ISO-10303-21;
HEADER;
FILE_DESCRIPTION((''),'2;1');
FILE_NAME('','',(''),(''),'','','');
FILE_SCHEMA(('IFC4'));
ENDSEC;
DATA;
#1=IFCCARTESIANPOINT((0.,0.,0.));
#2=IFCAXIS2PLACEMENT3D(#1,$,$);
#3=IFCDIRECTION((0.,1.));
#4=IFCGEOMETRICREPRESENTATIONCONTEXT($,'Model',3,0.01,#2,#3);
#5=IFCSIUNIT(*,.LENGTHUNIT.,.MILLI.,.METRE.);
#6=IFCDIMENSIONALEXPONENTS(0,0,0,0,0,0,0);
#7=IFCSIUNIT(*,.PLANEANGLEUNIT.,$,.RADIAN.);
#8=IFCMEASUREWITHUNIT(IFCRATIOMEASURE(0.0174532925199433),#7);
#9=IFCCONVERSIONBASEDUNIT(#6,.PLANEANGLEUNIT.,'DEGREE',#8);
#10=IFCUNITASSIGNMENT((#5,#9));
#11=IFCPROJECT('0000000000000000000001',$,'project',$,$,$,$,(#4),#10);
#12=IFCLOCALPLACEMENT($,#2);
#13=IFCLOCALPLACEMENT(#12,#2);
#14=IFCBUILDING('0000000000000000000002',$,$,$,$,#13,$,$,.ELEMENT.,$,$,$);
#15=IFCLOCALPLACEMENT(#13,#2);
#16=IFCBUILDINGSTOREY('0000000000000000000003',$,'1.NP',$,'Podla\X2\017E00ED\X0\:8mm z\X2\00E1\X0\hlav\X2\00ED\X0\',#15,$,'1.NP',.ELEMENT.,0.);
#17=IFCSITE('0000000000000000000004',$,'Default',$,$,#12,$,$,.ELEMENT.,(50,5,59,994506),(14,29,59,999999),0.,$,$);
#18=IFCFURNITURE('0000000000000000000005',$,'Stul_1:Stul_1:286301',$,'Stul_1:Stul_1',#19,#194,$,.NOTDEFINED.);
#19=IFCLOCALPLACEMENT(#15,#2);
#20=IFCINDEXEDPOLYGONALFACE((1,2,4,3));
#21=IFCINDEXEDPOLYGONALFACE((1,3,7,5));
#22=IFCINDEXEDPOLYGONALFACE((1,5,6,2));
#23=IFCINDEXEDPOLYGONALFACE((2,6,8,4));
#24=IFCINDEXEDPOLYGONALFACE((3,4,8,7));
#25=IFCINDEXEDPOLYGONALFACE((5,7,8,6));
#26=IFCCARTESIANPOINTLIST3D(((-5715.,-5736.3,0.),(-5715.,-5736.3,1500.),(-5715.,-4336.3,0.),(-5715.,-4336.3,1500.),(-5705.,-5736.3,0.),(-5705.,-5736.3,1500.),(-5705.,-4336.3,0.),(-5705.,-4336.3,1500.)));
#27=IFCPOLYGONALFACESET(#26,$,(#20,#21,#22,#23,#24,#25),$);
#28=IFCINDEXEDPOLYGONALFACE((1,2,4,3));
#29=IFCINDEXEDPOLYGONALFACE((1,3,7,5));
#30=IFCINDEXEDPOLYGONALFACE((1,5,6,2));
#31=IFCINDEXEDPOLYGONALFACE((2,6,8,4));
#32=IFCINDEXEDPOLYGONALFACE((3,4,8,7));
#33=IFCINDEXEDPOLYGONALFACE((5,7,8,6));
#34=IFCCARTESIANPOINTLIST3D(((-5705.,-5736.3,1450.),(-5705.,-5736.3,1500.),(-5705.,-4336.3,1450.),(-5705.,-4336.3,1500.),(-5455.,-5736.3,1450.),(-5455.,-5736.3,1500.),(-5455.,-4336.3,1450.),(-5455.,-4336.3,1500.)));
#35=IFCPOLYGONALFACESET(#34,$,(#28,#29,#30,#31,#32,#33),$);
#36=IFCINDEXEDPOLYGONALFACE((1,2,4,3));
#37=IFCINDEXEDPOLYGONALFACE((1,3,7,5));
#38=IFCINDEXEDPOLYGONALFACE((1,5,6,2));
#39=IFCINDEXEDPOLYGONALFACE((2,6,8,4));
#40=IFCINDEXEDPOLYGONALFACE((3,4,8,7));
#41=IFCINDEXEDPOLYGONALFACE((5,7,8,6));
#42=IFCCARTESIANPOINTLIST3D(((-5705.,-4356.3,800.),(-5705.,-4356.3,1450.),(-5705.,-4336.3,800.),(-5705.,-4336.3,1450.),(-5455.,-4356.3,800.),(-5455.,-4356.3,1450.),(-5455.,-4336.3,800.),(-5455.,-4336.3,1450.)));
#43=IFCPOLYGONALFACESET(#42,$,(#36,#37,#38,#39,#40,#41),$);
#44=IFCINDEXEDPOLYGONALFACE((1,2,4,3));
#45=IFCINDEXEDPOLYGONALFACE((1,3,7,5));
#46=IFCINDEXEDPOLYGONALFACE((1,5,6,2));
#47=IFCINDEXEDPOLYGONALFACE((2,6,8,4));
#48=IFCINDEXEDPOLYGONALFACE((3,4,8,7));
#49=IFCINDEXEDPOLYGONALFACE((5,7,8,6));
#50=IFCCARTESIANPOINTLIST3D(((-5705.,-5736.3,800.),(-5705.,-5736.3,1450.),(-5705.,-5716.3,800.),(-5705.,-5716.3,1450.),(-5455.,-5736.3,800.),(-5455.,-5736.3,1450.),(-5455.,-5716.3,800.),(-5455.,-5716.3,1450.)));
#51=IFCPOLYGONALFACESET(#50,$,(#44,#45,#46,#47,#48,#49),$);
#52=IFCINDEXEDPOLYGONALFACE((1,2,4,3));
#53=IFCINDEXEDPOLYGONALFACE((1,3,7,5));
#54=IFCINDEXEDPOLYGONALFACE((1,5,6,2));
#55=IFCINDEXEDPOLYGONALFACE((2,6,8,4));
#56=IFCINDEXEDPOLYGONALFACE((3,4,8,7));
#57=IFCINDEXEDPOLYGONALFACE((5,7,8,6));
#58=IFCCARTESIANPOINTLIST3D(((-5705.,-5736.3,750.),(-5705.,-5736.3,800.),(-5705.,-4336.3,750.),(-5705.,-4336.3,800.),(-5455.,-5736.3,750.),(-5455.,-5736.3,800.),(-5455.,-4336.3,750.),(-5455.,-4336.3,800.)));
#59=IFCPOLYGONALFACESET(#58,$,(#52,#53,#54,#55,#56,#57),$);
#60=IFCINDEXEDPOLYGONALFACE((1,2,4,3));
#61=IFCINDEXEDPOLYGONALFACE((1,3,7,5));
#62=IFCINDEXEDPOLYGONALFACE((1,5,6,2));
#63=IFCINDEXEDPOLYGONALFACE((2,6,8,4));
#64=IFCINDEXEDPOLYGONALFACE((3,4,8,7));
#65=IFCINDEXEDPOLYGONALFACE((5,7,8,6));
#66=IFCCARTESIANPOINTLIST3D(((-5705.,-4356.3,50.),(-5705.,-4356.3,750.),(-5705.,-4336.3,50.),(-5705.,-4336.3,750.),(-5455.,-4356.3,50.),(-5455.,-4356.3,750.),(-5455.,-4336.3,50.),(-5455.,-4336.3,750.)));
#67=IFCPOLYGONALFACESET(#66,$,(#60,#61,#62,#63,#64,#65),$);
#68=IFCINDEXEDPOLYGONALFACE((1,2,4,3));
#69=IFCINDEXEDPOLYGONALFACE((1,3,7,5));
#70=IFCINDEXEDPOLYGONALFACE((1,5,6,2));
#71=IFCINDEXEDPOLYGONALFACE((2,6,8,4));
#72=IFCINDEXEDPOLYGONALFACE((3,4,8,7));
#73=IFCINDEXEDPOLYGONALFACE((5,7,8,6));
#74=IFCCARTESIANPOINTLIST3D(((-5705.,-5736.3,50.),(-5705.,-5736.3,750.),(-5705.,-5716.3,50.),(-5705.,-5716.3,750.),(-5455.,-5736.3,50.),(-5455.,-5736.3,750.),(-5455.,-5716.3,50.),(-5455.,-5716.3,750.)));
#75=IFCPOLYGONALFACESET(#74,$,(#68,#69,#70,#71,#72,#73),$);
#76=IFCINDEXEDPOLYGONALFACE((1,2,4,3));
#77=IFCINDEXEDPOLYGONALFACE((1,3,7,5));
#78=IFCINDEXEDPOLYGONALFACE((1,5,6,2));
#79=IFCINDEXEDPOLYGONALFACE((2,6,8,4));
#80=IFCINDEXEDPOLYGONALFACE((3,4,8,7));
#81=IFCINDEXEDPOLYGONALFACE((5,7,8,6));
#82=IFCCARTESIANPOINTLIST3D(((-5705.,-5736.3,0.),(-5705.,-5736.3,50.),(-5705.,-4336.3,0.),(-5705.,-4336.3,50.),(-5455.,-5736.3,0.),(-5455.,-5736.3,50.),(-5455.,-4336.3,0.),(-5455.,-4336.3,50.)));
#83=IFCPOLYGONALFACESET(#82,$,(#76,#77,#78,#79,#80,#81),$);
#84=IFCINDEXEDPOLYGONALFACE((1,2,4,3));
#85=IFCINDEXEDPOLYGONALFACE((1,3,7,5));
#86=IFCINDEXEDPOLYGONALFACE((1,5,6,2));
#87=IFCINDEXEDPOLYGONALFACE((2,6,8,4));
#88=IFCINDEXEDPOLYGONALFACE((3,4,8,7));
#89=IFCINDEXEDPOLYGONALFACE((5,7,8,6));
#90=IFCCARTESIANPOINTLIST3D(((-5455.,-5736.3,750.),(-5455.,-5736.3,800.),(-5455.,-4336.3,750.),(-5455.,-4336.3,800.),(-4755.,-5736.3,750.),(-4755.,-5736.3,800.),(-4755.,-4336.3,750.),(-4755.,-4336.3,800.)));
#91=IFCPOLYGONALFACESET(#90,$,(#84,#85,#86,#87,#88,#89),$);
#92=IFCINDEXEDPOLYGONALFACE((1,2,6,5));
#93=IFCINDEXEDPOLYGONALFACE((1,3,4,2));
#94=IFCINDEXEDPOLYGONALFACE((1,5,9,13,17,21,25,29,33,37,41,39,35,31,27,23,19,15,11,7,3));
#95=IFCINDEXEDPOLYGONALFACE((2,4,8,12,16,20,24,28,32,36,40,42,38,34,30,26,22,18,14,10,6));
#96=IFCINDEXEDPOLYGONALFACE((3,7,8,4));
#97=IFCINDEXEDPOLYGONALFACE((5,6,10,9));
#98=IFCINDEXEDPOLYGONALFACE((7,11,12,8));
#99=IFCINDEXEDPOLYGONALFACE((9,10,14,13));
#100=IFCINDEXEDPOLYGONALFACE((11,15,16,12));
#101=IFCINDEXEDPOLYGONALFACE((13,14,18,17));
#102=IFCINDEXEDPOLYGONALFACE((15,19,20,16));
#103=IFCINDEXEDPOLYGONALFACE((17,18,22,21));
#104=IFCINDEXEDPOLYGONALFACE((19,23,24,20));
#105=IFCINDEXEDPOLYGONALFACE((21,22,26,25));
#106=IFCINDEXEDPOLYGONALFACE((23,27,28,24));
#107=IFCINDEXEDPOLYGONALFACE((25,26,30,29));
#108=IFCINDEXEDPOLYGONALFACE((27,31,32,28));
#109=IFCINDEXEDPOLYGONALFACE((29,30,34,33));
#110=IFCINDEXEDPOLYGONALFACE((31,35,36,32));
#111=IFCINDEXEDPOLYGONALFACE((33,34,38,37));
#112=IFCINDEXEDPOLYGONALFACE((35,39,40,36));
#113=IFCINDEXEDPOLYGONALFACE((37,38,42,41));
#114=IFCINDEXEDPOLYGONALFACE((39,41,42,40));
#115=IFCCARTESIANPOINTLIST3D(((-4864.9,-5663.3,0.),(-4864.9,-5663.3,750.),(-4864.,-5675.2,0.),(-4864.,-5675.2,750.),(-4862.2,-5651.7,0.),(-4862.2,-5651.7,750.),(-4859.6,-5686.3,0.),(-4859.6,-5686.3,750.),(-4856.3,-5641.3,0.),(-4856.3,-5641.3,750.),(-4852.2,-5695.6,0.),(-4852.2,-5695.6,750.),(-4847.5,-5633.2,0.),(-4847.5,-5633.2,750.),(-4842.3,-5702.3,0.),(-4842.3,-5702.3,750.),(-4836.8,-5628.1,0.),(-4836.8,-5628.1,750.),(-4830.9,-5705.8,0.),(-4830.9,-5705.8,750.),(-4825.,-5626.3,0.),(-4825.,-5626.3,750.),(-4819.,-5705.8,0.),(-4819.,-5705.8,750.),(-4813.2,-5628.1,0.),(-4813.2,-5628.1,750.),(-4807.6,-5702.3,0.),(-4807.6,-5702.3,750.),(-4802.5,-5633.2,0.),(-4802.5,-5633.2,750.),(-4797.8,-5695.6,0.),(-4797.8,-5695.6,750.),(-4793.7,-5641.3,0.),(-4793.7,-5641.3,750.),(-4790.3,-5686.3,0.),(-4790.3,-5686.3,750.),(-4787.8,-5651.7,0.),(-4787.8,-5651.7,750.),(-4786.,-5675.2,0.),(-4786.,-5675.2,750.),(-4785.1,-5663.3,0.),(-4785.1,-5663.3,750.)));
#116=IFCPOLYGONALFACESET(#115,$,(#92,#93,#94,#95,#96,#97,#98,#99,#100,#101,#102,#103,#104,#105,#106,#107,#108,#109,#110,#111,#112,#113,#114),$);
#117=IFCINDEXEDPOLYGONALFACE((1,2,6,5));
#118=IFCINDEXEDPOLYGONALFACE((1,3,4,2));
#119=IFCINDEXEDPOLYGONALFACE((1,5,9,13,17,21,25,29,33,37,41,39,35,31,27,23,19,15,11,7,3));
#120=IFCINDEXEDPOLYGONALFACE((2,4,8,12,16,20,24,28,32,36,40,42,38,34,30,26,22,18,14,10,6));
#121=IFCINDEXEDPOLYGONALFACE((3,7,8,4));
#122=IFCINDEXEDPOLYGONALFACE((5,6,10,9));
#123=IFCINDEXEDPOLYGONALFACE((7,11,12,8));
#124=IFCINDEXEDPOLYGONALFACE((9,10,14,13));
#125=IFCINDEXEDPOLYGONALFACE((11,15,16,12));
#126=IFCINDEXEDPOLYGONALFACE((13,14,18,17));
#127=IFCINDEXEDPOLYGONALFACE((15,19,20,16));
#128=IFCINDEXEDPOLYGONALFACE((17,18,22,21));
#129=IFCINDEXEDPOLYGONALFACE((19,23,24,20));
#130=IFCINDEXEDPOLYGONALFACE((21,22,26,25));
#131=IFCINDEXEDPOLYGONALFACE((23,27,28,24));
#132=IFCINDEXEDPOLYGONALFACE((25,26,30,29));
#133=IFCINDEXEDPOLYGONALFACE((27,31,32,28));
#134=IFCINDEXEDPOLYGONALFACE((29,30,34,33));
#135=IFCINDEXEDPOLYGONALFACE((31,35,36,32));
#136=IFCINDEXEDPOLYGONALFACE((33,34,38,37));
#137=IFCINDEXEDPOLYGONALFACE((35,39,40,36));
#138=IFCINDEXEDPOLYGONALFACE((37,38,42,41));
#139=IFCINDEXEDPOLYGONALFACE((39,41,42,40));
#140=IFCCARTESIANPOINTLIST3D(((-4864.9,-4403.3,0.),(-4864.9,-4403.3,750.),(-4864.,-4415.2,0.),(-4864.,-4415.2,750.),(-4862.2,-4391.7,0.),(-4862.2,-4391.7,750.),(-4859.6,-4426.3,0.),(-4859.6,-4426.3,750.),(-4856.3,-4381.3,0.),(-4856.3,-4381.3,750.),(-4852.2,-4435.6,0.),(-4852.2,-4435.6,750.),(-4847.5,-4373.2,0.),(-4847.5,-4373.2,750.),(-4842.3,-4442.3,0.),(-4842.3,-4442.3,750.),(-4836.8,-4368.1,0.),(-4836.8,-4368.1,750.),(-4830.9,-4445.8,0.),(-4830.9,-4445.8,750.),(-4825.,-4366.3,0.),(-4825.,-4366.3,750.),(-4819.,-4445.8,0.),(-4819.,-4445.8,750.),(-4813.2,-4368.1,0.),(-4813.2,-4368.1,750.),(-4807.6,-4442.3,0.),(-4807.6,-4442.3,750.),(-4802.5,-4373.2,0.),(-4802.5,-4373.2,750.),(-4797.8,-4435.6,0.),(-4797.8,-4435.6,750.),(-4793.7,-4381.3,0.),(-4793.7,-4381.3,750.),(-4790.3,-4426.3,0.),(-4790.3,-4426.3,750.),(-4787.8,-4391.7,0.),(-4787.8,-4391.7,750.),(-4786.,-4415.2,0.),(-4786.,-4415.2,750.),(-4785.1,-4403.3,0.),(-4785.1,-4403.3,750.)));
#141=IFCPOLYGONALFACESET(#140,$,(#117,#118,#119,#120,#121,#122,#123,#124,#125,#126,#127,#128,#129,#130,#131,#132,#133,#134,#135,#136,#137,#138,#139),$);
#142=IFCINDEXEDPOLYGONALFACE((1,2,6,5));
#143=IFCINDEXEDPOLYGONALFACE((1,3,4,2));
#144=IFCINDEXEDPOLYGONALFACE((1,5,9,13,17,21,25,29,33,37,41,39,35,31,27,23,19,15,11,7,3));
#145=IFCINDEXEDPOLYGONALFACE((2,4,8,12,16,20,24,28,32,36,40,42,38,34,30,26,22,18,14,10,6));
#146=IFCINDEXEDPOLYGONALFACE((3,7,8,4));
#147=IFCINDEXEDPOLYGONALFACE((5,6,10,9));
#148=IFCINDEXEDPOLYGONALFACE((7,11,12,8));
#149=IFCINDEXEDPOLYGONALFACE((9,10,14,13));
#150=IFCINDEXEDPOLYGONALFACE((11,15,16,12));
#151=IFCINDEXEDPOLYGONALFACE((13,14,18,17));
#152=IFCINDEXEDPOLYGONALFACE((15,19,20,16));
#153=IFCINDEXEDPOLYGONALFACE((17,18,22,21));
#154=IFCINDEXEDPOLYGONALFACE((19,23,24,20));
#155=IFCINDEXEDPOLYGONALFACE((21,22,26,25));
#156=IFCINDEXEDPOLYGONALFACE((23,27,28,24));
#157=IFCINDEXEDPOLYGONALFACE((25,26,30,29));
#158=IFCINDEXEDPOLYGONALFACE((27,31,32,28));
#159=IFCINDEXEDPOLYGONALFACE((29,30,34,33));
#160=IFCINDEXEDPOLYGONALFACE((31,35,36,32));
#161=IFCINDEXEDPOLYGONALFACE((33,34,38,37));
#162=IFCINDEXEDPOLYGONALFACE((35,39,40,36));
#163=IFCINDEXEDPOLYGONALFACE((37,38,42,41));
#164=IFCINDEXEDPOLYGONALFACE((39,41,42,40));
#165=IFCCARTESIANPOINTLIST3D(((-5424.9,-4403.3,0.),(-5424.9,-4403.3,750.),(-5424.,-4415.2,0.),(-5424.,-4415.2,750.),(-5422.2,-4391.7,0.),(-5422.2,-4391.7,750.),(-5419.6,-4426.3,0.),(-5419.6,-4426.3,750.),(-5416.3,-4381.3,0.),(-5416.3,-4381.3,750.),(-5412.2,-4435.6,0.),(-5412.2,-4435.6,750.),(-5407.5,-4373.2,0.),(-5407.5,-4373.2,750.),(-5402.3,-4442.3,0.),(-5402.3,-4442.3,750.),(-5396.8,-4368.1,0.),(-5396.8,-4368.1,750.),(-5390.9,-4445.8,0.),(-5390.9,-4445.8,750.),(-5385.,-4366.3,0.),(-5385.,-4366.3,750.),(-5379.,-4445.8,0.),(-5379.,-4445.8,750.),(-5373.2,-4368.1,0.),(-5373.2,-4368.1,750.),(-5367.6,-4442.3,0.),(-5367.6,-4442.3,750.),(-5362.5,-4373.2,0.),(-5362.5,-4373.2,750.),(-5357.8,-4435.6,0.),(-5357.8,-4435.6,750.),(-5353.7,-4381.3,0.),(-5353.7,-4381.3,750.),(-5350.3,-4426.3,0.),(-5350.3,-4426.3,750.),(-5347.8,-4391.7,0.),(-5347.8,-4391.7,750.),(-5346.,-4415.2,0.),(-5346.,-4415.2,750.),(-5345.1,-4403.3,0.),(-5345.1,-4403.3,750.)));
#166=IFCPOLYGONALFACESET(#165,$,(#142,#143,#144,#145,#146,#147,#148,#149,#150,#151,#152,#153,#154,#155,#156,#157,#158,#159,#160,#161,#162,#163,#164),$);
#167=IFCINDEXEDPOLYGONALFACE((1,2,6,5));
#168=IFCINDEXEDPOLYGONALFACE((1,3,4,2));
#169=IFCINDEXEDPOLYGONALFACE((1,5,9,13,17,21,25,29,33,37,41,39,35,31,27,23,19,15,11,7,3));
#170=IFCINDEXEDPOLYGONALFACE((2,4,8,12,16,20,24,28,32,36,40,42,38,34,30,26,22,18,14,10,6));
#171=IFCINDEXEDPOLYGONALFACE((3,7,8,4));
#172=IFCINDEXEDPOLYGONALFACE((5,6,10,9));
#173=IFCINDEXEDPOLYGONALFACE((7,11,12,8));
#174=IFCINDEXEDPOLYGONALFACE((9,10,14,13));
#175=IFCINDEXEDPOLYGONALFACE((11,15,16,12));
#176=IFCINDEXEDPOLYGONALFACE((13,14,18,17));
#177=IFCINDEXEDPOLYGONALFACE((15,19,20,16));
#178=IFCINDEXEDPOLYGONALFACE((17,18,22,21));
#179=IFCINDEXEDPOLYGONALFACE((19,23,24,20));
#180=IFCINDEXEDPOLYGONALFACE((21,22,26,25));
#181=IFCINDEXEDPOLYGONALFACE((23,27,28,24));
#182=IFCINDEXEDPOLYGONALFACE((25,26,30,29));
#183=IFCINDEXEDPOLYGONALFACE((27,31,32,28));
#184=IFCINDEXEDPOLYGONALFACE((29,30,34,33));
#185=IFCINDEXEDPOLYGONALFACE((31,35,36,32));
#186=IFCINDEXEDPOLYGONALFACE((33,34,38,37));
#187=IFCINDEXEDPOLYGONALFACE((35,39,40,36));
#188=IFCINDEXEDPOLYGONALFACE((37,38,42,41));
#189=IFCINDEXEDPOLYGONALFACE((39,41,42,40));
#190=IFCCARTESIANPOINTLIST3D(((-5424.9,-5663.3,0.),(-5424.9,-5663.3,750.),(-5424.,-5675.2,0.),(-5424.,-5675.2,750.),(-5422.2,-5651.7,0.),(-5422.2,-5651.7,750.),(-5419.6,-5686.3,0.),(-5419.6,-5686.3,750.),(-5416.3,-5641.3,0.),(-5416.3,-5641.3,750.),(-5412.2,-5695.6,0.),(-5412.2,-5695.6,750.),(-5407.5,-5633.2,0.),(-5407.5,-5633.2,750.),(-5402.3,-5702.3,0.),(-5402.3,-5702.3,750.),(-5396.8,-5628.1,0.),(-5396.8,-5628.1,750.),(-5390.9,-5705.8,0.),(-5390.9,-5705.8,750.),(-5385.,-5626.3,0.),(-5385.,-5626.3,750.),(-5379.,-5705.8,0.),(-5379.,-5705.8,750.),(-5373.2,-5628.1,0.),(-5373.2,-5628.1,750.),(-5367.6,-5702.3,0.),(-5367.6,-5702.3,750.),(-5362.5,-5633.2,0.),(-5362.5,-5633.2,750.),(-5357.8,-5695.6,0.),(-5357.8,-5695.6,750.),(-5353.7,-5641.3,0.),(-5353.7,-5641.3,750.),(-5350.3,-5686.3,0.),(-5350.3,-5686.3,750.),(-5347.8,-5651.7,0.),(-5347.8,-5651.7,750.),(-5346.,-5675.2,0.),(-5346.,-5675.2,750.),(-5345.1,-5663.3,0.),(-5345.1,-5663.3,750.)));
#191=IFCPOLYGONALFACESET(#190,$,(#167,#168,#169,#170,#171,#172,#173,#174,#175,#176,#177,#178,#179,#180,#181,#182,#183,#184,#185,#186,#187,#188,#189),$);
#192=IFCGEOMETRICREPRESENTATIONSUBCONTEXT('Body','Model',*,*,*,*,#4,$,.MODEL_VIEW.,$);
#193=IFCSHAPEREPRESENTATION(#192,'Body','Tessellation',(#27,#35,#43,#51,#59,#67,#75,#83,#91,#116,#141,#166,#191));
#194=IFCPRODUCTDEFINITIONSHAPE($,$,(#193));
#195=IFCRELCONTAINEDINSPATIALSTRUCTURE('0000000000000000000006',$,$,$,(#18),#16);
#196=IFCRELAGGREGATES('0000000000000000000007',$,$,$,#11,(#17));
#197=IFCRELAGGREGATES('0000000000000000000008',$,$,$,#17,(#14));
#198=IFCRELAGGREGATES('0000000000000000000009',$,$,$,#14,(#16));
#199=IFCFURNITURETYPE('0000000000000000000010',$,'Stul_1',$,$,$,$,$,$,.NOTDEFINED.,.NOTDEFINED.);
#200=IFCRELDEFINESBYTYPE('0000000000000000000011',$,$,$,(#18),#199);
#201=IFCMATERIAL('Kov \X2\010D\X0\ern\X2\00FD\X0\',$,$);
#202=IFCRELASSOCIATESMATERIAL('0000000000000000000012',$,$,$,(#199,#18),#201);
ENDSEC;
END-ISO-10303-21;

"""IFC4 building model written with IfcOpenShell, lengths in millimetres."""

from ifc_helpers import new_model, entity, si_unit, converted_unit, direction, frame, frame_2d, origin, origin_2d_with_axis, place, context, subcontext, project, spatial, rectangle, circle, extrude, source, transform, mapped, material, type_object, type_shapes, element, save


model = new_model("IFC4")

# Units and contexts
model_context = context("Model", 3, precision=0.01, world=origin(), true_north=direction((0.0, 1.0)))
body_context = subcontext(model_context, "Body", "Model", "MODEL_VIEW")
ifc_project = project(units=[si_unit("LENGTHUNIT", "METRE", prefix="MILLI"), converted_unit("PLANEANGLEUNIT", "DEGREE", entity("IfcRatioMeasure", 0.0174532925199433), si_unit("PLANEANGLEUNIT", "RADIAN"), dimensions=[0, 0, 0, 0, 0, 0, 0])], contexts=[model_context])

# Site, building, storey
site_placement = place(None, origin())
site = spatial("IfcSite", under=ifc_project, at=site_placement, Name="Default", CompositionType="ELEMENT", RefLatitude=(50, 5, 59, 994506), RefLongitude=(14, 29, 59, 999999), RefElevation=0.0)
building_placement = place(site_placement, origin())
building = spatial("IfcBuilding", under=site, at=building_placement, CompositionType="ELEMENT")
storey_placement = place(building_placement, origin())
storey = spatial("IfcBuildingStorey", under=building, at=storey_placement, Name="1.NP", ObjectType="Podlaží:8mm záhlaví", LongName="1.NP", CompositionType="ELEMENT", Elevation=0.0)

# Furniture
ifc_material_1 = material(Name="Kov černý")
furniture_type = type_object("IfcFurnitureType", Name="Stul_1", AssemblyPlace="NOTDEFINED", PredefinedType="NOTDEFINED", material=ifc_material_1)
shared_shape_1 = source(origin(), body_context, "Body", "SweptSolid", [
    extrude(rectangle(XDim=1400.0, YDim=10.0, at=origin_2d_with_axis()), frame((0.0, 605.0, 0.0), z_axis=(0.0, 0.0, 1.0), x_axis=(-1.0, 0.0, 0.0)), (0.0, 0.0, 1.0), 1500.0),
    extrude(rectangle(XDim=1400.0, YDim=250.0, at=frame_2d((0.0, 0.0), x_axis=(1.0, 0.0))), frame((0.0, 475.0, 1450.0), z_axis=(0.0, 0.0, 1.0), x_axis=(-1.0, 0.0, 0.0)), (0.0, 0.0, 1.0), 50.0),
    extrude(rectangle(XDim=20.0, YDim=250.0, at=origin_2d_with_axis()), frame((690.0, 475.0, 800.0), z_axis=(0.0, 0.0, 1.0), x_axis=(-1.0, 0.0, 0.0)), (0.0, 0.0, 1.0), 650.0),
    extrude(rectangle(XDim=20.0, YDim=250.0, at=frame_2d((0.0, 0.0), x_axis=(1.0, 0.0))), frame((-690.0, 475.0, 800.0), z_axis=(0.0, 0.0, 1.0), x_axis=(-1.0, 0.0, 0.0)), (0.0, 0.0, 1.0), 650.0),
    extrude(rectangle(XDim=1400.0, YDim=250.0, at=origin_2d_with_axis()), frame((0.0, 475.0, 750.0), z_axis=(0.0, 0.0, 1.0), x_axis=(-1.0, 0.0, 0.0)), (0.0, 0.0, 1.0), 50.0),
    extrude(rectangle(XDim=20.0, YDim=250.0, at=origin_2d_with_axis()), frame((690.0, 475.0, 50.0), z_axis=(0.0, 0.0, 1.0), x_axis=(-1.0, 0.0, 0.0)), (0.0, 0.0, 1.0), 700.0),
    extrude(rectangle(XDim=20.0, YDim=250.0, at=frame_2d((0.0, 0.0), x_axis=(1.0, 0.0))), frame((-690.0, 475.0, 50.0), z_axis=(0.0, 0.0, 1.0), x_axis=(-1.0, 0.0, 0.0)), (0.0, 0.0, 1.0), 700.0),
    extrude(rectangle(XDim=1400.0, YDim=250.0, at=origin_2d_with_axis()), frame((0.0, 475.0, 0.0), z_axis=(0.0, 0.0, 1.0), x_axis=(-1.0, 0.0, 0.0)), (0.0, 0.0, 1.0), 50.0),
    extrude(rectangle(XDim=1400.0, YDim=700.0, at=origin_2d_with_axis()), frame((0.0, 0.0, 750.0), z_axis=(0.0, 0.0, 1.0), x_axis=(-1.0, 0.0, 0.0)), (0.0, 0.0, 1.0), 50.0),
    extrude(circle(Radius=40.0, at=frame_2d((0.0, 0.0), x_axis=(1.0, 0.0))), frame((-630.0, -280.0, 0.0)), (0.0, 0.0, 1.0), 750.0),
    extrude(circle(Radius=40.0, at=frame_2d((0.0, 0.0), x_axis=(1.0, 0.0))), frame((630.0, -280.0, 0.0)), (0.0, 0.0, 1.0), 750.0),
    extrude(circle(Radius=40.0, at=frame_2d((0.0, 0.0), x_axis=(1.0, 0.0))), frame((630.0, 280.0, 0.0)), (0.0, 0.0, 1.0), 750.0),
    extrude(circle(Radius=40.0, at=frame_2d((0.0, 0.0), x_axis=(1.0, 0.0))), frame((-630.0, 280.0, 0.0)), (0.0, 0.0, 1.0), 750.0),
])
type_shapes(furniture_type, [shared_shape_1])
for number, where, z_axis, x_axis, name in (
    (1, (-5105.0, -5036.3, 0.0), (0.0, 0.0, 1.0), (0.0, 1.0, 0.0), "Stul_1:Stul_1:286301"),
):
    element("IfcFurniture", number, at=place(storey_placement, frame(where, z_axis=z_axis, x_axis=x_axis)), inside=storey, type_object=furniture_type, material=ifc_material_1, Name=name, ObjectType="Stul_1:Stul_1", PredefinedType="NOTDEFINED", context=body_context, shape_type="MappedRepresentation", body=[
        mapped(shared_shape_1, transform((0.0, 0.0, 0.0), scale=1.0)),
    ])

save(model, "model.ifc")
